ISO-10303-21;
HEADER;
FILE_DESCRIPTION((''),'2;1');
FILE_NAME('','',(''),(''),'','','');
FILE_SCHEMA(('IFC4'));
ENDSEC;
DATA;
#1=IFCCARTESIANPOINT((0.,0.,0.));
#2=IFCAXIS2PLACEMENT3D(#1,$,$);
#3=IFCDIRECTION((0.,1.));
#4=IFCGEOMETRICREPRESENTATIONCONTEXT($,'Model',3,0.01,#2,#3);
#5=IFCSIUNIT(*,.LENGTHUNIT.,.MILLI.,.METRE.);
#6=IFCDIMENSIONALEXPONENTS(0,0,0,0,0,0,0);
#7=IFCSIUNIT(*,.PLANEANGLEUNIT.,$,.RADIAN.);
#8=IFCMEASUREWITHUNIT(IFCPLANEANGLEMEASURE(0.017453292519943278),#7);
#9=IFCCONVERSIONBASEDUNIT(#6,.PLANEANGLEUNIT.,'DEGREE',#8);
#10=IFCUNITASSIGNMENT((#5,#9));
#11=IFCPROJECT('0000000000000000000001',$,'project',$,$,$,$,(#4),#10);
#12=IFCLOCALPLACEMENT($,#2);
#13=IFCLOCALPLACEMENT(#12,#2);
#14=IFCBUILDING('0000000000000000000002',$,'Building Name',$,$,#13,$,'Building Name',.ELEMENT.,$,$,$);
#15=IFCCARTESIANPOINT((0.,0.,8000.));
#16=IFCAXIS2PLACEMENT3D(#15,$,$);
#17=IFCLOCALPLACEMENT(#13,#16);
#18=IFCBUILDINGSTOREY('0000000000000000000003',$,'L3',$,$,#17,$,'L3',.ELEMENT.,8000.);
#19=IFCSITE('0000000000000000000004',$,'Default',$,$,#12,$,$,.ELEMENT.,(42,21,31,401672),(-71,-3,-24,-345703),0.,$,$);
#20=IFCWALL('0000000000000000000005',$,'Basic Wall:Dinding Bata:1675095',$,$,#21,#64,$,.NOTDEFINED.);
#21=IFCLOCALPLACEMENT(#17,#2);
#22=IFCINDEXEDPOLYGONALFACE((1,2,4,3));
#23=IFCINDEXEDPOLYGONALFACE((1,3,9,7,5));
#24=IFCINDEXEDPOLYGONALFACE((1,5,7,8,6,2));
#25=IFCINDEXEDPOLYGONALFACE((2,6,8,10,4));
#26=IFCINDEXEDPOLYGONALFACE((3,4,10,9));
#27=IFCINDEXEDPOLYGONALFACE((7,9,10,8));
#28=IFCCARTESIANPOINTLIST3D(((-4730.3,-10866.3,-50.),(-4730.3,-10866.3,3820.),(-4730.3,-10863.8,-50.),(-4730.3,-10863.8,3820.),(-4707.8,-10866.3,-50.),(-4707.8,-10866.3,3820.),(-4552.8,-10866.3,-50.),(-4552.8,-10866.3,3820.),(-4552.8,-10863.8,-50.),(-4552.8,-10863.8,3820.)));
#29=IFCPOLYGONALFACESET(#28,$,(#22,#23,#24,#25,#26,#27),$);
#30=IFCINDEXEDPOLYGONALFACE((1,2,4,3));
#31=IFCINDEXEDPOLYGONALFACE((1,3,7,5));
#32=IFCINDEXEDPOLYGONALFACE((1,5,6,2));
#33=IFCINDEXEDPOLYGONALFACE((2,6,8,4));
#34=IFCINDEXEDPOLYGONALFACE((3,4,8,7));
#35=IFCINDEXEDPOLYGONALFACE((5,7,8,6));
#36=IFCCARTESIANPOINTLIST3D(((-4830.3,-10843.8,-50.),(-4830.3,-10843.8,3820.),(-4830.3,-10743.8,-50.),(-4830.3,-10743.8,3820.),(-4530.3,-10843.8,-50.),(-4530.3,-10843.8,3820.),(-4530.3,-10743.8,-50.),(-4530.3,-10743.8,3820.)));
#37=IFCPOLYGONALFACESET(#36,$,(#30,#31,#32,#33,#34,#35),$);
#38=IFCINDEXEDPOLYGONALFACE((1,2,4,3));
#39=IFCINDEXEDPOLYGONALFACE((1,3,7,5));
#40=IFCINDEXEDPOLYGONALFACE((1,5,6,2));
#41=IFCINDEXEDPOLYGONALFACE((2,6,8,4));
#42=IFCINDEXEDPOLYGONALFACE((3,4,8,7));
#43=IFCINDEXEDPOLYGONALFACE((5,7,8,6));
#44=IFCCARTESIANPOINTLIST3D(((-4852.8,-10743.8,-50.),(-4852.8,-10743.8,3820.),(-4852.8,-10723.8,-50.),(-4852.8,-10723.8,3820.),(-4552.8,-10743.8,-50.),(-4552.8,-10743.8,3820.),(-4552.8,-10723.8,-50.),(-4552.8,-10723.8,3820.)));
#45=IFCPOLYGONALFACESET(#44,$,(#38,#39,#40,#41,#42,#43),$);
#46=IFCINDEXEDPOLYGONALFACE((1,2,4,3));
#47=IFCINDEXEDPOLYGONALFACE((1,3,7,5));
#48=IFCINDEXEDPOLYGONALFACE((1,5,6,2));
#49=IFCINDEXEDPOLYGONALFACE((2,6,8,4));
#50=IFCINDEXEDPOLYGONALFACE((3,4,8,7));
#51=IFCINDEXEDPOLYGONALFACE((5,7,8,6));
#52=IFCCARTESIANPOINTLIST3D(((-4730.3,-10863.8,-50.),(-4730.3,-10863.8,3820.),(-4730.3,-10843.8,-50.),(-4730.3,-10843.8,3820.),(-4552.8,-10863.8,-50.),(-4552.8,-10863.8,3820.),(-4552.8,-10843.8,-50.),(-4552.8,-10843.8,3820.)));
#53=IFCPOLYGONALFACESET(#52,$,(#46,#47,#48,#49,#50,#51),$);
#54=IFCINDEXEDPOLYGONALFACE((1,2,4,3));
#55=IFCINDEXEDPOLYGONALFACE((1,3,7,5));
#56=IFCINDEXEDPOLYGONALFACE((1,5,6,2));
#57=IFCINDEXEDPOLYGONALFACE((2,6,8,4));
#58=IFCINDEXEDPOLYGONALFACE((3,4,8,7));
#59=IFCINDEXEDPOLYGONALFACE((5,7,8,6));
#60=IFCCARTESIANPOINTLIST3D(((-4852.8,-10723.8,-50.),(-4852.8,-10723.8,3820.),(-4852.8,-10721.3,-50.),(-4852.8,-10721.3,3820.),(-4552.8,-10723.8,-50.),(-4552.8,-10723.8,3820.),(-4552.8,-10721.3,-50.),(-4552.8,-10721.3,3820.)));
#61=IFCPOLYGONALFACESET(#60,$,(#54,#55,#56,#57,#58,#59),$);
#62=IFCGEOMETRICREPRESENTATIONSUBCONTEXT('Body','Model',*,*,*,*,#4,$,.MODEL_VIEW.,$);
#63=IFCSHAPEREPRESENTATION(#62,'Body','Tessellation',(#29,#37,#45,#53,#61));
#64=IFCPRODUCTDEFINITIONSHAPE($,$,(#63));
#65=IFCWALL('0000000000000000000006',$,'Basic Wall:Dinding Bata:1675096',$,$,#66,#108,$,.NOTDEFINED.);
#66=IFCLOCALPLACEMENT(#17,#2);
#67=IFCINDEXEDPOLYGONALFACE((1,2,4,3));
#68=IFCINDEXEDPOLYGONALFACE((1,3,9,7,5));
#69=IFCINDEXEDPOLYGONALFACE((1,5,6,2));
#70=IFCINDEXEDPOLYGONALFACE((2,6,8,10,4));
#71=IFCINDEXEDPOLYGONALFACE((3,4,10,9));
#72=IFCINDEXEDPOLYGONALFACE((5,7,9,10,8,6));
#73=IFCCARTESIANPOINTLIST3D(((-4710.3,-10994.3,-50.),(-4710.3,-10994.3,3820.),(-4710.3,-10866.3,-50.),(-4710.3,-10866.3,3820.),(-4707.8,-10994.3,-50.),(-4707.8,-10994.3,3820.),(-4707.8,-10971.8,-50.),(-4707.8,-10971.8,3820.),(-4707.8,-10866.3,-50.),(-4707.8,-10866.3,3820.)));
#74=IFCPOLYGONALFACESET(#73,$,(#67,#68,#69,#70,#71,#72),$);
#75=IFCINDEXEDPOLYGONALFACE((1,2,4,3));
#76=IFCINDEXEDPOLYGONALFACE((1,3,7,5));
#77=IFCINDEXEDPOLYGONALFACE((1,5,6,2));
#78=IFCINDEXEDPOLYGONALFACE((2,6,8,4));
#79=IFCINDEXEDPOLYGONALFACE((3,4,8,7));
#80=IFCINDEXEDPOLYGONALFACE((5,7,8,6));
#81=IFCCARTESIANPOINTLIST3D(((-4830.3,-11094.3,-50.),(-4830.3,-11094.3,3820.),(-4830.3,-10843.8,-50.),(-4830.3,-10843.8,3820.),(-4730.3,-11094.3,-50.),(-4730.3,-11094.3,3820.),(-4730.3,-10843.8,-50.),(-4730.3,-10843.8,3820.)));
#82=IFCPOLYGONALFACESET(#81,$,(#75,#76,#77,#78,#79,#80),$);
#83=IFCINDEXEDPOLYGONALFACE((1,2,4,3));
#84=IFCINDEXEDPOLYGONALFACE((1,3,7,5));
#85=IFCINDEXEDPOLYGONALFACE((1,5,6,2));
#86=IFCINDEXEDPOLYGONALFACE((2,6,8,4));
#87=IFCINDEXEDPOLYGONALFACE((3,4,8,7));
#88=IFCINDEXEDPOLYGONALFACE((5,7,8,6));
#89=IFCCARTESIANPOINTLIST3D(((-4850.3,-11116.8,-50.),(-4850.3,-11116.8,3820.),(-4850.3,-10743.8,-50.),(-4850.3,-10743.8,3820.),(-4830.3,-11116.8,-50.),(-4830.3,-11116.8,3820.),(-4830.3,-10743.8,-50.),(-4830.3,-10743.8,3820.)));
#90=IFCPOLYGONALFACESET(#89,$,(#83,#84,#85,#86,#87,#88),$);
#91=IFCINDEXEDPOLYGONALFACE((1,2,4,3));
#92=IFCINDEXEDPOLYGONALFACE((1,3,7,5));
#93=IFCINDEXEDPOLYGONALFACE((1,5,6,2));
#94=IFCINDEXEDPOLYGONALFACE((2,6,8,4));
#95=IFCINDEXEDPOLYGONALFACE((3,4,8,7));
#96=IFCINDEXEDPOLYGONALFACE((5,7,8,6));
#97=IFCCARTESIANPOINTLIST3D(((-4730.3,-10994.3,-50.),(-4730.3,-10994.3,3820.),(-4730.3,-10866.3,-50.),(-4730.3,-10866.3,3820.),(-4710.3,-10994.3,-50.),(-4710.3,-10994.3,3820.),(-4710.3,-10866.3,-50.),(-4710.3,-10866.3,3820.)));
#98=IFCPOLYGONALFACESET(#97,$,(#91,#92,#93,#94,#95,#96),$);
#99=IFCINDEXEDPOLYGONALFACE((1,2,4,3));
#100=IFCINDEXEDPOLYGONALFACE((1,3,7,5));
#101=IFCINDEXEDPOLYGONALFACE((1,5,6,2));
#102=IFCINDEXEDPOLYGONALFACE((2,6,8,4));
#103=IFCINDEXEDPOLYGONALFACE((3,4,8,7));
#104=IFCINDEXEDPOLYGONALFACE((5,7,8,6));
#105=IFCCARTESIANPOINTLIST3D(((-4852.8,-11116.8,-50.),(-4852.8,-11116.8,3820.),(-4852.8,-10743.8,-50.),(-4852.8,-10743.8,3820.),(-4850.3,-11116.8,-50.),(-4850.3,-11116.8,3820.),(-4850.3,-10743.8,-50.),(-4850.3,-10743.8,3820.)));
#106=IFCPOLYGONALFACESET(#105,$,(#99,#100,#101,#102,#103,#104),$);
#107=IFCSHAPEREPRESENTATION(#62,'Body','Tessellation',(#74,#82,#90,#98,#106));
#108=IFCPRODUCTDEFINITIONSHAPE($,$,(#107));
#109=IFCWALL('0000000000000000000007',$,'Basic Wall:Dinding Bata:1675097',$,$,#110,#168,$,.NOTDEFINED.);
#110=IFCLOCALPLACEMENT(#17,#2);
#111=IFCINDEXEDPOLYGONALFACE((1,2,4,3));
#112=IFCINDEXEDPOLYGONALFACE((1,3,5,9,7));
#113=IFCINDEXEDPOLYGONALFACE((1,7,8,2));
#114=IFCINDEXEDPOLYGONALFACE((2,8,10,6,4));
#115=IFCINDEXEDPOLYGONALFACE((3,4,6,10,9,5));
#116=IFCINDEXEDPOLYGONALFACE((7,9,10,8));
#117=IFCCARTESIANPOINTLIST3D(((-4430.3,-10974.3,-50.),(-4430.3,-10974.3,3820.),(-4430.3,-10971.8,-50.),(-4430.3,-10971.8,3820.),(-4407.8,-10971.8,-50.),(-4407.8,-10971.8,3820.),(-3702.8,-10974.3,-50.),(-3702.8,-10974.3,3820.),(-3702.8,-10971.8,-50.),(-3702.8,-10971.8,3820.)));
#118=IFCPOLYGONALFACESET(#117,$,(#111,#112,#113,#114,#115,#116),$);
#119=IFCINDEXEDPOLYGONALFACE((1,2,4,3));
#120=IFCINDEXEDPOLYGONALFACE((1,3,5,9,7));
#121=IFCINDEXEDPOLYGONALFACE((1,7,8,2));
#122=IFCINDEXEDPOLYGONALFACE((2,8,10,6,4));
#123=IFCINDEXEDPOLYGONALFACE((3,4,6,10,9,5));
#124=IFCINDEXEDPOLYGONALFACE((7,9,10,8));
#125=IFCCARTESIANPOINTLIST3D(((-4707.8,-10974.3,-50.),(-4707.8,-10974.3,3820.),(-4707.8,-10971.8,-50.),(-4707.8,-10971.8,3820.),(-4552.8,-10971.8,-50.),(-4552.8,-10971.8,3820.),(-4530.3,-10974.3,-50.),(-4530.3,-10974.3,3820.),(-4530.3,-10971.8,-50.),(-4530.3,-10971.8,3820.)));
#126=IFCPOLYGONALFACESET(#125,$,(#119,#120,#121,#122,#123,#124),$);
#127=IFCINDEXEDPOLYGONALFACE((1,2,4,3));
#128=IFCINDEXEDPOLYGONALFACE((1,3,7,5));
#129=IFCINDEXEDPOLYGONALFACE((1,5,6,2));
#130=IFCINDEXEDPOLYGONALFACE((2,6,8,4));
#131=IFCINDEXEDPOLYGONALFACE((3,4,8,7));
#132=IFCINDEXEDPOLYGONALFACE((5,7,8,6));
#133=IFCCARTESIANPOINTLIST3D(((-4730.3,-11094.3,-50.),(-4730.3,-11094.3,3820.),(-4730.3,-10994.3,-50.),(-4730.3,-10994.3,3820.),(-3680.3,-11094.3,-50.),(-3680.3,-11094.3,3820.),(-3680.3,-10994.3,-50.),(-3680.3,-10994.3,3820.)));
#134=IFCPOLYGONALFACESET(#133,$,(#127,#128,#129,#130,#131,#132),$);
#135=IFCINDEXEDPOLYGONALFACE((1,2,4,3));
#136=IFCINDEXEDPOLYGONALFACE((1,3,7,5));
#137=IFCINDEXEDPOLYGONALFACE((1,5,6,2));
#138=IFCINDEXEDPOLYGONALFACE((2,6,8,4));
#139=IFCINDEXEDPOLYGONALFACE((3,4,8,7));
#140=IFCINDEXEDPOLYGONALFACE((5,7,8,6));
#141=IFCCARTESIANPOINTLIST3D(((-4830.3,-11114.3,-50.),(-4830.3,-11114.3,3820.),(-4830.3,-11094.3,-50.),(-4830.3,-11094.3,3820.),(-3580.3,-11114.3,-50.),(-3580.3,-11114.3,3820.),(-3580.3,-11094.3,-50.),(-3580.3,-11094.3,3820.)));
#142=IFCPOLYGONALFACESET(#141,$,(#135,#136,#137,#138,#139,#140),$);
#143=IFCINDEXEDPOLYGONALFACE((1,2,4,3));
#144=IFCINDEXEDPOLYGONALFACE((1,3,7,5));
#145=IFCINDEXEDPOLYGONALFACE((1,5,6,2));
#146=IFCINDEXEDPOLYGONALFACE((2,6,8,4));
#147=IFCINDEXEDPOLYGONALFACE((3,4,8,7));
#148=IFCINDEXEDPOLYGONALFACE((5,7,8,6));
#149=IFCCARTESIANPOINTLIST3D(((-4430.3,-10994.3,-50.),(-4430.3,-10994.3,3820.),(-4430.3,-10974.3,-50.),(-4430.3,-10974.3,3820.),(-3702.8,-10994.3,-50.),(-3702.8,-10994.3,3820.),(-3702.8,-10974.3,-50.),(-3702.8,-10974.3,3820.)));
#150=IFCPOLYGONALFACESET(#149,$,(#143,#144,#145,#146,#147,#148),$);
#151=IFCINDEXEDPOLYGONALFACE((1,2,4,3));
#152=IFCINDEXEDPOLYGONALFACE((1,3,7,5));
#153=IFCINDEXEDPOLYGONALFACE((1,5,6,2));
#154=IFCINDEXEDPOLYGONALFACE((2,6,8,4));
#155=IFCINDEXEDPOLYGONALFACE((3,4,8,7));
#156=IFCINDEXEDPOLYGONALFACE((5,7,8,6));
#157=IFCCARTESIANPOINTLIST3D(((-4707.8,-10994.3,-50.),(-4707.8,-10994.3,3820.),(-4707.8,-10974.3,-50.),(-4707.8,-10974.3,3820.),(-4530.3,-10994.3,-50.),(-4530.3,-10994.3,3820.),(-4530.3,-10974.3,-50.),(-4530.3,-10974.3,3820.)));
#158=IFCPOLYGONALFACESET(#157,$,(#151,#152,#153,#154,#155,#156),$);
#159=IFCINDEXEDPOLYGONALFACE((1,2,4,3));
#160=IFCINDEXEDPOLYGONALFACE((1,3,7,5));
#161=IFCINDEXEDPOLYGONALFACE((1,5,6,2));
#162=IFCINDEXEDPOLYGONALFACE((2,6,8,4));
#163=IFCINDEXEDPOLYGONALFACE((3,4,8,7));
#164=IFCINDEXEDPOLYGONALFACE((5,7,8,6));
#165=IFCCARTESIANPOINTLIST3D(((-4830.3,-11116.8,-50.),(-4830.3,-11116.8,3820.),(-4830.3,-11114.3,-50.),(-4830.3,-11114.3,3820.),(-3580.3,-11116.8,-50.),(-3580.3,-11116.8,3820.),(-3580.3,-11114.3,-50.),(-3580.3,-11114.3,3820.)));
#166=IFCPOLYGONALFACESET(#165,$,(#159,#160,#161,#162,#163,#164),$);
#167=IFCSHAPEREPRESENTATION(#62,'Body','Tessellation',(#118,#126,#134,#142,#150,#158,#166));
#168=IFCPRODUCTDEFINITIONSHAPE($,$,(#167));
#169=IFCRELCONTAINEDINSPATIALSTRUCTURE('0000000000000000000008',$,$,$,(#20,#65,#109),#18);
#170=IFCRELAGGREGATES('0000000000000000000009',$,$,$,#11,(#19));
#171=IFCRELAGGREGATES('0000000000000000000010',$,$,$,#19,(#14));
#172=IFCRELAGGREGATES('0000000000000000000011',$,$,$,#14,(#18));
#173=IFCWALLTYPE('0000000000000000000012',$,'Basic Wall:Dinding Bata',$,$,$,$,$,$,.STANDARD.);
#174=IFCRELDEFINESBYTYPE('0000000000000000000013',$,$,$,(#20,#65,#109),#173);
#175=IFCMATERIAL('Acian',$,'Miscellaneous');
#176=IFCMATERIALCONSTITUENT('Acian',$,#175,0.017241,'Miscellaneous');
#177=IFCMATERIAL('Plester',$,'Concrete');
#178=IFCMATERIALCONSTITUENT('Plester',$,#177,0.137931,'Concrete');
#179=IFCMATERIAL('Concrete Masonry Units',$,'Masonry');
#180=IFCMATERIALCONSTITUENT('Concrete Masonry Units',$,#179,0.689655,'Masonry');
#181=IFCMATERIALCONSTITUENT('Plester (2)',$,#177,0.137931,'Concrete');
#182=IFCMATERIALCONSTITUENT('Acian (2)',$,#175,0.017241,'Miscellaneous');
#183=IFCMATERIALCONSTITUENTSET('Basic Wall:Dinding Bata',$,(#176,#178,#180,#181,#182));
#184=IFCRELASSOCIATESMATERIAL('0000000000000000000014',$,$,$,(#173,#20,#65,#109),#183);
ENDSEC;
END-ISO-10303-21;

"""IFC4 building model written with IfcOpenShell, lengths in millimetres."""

from ifc_helpers import new_model, entity, si_unit, converted_unit, direction, frame, origin, place, context, subcontext, project, spatial, indexed_curve, outline, extrude, material, constituent, constituent_set, type_object, element, save


model = new_model("IFC4")

# Units and contexts
model_context = context("Model", 3, precision=0.01, world=origin(), true_north=direction((0.0, 1.0)))
body_context = subcontext(model_context, "Body", "Model", "MODEL_VIEW")
ifc_project = project(units=[si_unit("LENGTHUNIT", "METRE", prefix="MILLI"), converted_unit("PLANEANGLEUNIT", "DEGREE", entity("IfcPlaneAngleMeasure", 0.017453292519943278), si_unit("PLANEANGLEUNIT", "RADIAN"), dimensions=[0, 0, 0, 0, 0, 0, 0])], contexts=[model_context])

# Site, building, storey
site_placement = place(None, origin())
site = spatial("IfcSite", under=ifc_project, at=site_placement, Name="Default", CompositionType="ELEMENT", RefLatitude=(42, 21, 31, 401672), RefLongitude=(-71, -3, -24, -345703), RefElevation=0.0)
building_placement = place(site_placement, origin())
building = spatial("IfcBuilding", under=site, at=building_placement, Name="Building Name", LongName="Building Name", CompositionType="ELEMENT")
storey_placement = place(building_placement, frame((0.0, 0.0, 8000.0)))
storey = spatial("IfcBuildingStorey", under=building, at=storey_placement, Name="L3", LongName="L3", CompositionType="ELEMENT", Elevation=8000.0)

# Walls
ifc_material_1 = material(Name="Acian", Category="Miscellaneous")
ifc_constituent_1 = constituent(ifc_material_1, Name="Acian", Category="Miscellaneous", fraction=0.017241)
ifc_material_2 = material(Name="Plester", Category="Concrete")
ifc_constituent_2 = constituent(ifc_material_2, Name="Plester", Category="Concrete", fraction=0.137931)
ifc_material_3 = material(Name="Concrete Masonry Units", Category="Masonry")
ifc_constituent_3 = constituent(ifc_material_3, Name="Concrete Masonry Units", Category="Masonry", fraction=0.689655)
ifc_constituent_4 = constituent(ifc_material_2, Name="Plester (2)", Category="Concrete", fraction=0.137931)
ifc_constituent_5 = constituent(ifc_material_1, Name="Acian (2)", Category="Miscellaneous", fraction=0.017241)
ifc_constituent_set = constituent_set(constituents=[ifc_constituent_1, ifc_constituent_2, ifc_constituent_3, ifc_constituent_4, ifc_constituent_5], Name="Basic Wall:Dinding Bata")
wall_type = type_object("IfcWallType", Name="Basic Wall:Dinding Bata", PredefinedType="STANDARD", material=ifc_constituent_set)
wall_1_placement = place(storey_placement, frame((-4552.8, -10793.8, -50.0), z_axis=(0.0, 0.0, 1.0), x_axis=(-1.0, 0.0, 0.0)))
element("IfcWall", 1, at=wall_1_placement, inside=storey, type_object=wall_type, material=ifc_constituent_set, Name="Basic Wall:Dinding Bata:1675095", PredefinedType="NOTDEFINED", context=body_context, shape_type="SweptSolid", body=[
    extrude(outline(indexed_curve([(-53.0, -1.0), (102.0, -1.0), (102.0, 1.5), (-75.5, 1.5), (-75.5, -1.0), (-53.0, -1.0)], self_intersect=False)), frame((102.0, 71.5, 0.0), z_axis=(0.0, 0.0, 1.0), x_axis=(-1.0, 0.0, 0.0)), (0.0, 0.0, 1.0), 3870.0),
    extrude(outline(indexed_curve([(-150.0, -50.0), (150.0, -50.0), (150.0, 50.0), (-150.0, 50.0), (-150.0, -50.0)], self_intersect=False)), frame((127.5, 0.0, 0.0)), (0.0, 0.0, 1.0), 3870.0),
    extrude(outline(indexed_curve([(-150.0, -10.0), (150.0, -10.0), (150.0, 10.0), (-150.0, 10.0), (-150.0, -10.0)], self_intersect=False)), frame((150.0, -60.0, 0.0)), (0.0, 0.0, 1.0), 3870.0),
    extrude(outline(indexed_curve([(-88.8, -10.0), (88.8, -10.0), (88.8, 10.0), (-88.8, 10.0), (-88.8, -10.0)], self_intersect=False)), frame((88.8, 60.0, 0.0)), (0.0, 0.0, 1.0), 3870.0),
    extrude(outline(indexed_curve([(-1.2, -150.0), (1.2, -150.0), (1.2, 150.0), (-1.2, 150.0), (-1.2, -150.0)], self_intersect=False)), frame((150.0, -71.2, 0.0), z_axis=(0.0, 0.0, 1.0), x_axis=(0.0, 1.0, 0.0)), (0.0, 0.0, 1.0), 3870.0),
])
wall_2_placement = place(storey_placement, frame((-4780.3, -10866.3, -50.0), z_axis=(0.0, 0.0, 1.0), x_axis=(0.0, -1.0, 0.0)))
element("IfcWall", 2, at=wall_2_placement, inside=storey, type_object=wall_type, material=ifc_constituent_set, Name="Basic Wall:Dinding Bata:1675096", PredefinedType="NOTDEFINED", context=body_context, shape_type="SweptSolid", body=[
    extrude(outline(indexed_curve([(-33.2, -1.0), (72.3, -1.0), (72.3, 1.5), (-55.7, 1.5), (-55.7, -1.0), (-33.2, -1.0)], self_intersect=False)), frame((72.3, 71.5, 0.0), z_axis=(0.0, 0.0, 1.0), x_axis=(-1.0, 0.0, 0.0)), (0.0, 0.0, 1.0), 3870.0),
    extrude(outline(indexed_curve([(-125.2, -50.0), (125.2, -50.0), (125.2, 50.0), (-125.2, 50.0), (-125.2, -50.0)], self_intersect=False)), frame((102.7, 0.0, 0.0)), (0.0, 0.0, 1.0), 3870.0),
    extrude(outline(indexed_curve([(-186.5, -10.0), (186.5, -10.0), (186.5, 10.0), (-186.5, 10.0), (-186.5, -10.0)], self_intersect=False)), frame((64.0, -60.0, 0.0)), (0.0, 0.0, 1.0), 3870.0),
    extrude(outline(indexed_curve([(-64.0, -10.0), (64.0, -10.0), (64.0, 10.0), (-64.0, 10.0), (-64.0, -10.0)], self_intersect=False)), frame((64.0, 60.0, 0.0)), (0.0, 0.0, 1.0), 3870.0),
    extrude(outline(indexed_curve([(-1.3, -186.5), (1.2, -186.5), (1.3, 186.5), (-1.3, 186.5), (-1.3, -186.5)], self_intersect=False)), frame((64.0, -71.2, 0.0), z_axis=(0.0, 0.0, 1.0), x_axis=(0.0, 1.0, 0.0)), (0.0, 0.0, 1.0), 3870.0),
])
wall_3_placement = place(storey_placement, frame((-4707.8, -11044.3, -50.0)))
element("IfcWall", 3, at=wall_3_placement, inside=storey, type_object=wall_type, material=ifc_constituent_set, Name="Basic Wall:Dinding Bata:1675097", PredefinedType="NOTDEFINED", context=body_context, shape_type="SweptSolid", body=[
    extrude(outline(indexed_curve([(273.0, -1.0), (295.5, -1.0), (295.5, 1.5), (-432.0, 1.5), (-432.0, -1.0), (273.0, -1.0)], self_intersect=False)), frame((573.0, 71.5, 0.0), z_axis=(0.0, 0.0, 1.0), x_axis=(-1.0, 0.0, 0.0)), (0.0, 0.0, 1.0), 3870.0),
    extrude(outline(indexed_curve([(-102.0, -1.5), (75.5, -1.5), (75.5, 1.0), (53.0, 1.0), (-102.0, 1.0), (-102.0, -1.5)], self_intersect=False)), frame((102.0, 71.5, 0.0)), (0.0, 0.0, 1.0), 3870.0),
    extrude(outline(indexed_curve([(-525.0, -50.0), (525.0, -50.0), (525.0, 50.0), (-525.0, 50.0), (-525.0, -50.0)], self_intersect=False)), frame((502.5, 0.0, 0.0)), (0.0, 0.0, 1.0), 3870.0),
    extrude(outline(indexed_curve([(-625.0, -10.0), (625.0, -10.0), (625.0, 10.0), (-625.0, 10.0), (-625.0, -10.0)], self_intersect=False)), frame((502.5, -60.0, 0.0)), (0.0, 0.0, 1.0), 3870.0),
    extrude(outline(indexed_curve([(-363.7, -10.0), (363.7, -10.0), (363.7, 10.0), (-363.7, 10.0), (-363.7, -10.0)], self_intersect=False)), frame((641.3, 60.0, 0.0), z_axis=(0.0, 0.0, 1.0), x_axis=(-1.0, 0.0, 0.0)), (0.0, 0.0, 1.0), 3870.0),
    extrude(outline(indexed_curve([(-88.8, -10.0), (88.8, -10.0), (88.8, 10.0), (-88.8, 10.0), (-88.8, -10.0)], self_intersect=False)), frame((88.8, 60.0, 0.0)), (0.0, 0.0, 1.0), 3870.0),
    extrude(outline(indexed_curve([(-1.3, -625.0), (1.2, -625.0), (1.3, 625.0), (-1.2, 625.0), (-1.3, -625.0)], self_intersect=False)), frame((502.5, -71.2, 0.0), z_axis=(0.0, 0.0, 1.0), x_axis=(0.0, 1.0, 0.0)), (0.0, 0.0, 1.0), 3870.0),
])

save(model, "model.ifc")
